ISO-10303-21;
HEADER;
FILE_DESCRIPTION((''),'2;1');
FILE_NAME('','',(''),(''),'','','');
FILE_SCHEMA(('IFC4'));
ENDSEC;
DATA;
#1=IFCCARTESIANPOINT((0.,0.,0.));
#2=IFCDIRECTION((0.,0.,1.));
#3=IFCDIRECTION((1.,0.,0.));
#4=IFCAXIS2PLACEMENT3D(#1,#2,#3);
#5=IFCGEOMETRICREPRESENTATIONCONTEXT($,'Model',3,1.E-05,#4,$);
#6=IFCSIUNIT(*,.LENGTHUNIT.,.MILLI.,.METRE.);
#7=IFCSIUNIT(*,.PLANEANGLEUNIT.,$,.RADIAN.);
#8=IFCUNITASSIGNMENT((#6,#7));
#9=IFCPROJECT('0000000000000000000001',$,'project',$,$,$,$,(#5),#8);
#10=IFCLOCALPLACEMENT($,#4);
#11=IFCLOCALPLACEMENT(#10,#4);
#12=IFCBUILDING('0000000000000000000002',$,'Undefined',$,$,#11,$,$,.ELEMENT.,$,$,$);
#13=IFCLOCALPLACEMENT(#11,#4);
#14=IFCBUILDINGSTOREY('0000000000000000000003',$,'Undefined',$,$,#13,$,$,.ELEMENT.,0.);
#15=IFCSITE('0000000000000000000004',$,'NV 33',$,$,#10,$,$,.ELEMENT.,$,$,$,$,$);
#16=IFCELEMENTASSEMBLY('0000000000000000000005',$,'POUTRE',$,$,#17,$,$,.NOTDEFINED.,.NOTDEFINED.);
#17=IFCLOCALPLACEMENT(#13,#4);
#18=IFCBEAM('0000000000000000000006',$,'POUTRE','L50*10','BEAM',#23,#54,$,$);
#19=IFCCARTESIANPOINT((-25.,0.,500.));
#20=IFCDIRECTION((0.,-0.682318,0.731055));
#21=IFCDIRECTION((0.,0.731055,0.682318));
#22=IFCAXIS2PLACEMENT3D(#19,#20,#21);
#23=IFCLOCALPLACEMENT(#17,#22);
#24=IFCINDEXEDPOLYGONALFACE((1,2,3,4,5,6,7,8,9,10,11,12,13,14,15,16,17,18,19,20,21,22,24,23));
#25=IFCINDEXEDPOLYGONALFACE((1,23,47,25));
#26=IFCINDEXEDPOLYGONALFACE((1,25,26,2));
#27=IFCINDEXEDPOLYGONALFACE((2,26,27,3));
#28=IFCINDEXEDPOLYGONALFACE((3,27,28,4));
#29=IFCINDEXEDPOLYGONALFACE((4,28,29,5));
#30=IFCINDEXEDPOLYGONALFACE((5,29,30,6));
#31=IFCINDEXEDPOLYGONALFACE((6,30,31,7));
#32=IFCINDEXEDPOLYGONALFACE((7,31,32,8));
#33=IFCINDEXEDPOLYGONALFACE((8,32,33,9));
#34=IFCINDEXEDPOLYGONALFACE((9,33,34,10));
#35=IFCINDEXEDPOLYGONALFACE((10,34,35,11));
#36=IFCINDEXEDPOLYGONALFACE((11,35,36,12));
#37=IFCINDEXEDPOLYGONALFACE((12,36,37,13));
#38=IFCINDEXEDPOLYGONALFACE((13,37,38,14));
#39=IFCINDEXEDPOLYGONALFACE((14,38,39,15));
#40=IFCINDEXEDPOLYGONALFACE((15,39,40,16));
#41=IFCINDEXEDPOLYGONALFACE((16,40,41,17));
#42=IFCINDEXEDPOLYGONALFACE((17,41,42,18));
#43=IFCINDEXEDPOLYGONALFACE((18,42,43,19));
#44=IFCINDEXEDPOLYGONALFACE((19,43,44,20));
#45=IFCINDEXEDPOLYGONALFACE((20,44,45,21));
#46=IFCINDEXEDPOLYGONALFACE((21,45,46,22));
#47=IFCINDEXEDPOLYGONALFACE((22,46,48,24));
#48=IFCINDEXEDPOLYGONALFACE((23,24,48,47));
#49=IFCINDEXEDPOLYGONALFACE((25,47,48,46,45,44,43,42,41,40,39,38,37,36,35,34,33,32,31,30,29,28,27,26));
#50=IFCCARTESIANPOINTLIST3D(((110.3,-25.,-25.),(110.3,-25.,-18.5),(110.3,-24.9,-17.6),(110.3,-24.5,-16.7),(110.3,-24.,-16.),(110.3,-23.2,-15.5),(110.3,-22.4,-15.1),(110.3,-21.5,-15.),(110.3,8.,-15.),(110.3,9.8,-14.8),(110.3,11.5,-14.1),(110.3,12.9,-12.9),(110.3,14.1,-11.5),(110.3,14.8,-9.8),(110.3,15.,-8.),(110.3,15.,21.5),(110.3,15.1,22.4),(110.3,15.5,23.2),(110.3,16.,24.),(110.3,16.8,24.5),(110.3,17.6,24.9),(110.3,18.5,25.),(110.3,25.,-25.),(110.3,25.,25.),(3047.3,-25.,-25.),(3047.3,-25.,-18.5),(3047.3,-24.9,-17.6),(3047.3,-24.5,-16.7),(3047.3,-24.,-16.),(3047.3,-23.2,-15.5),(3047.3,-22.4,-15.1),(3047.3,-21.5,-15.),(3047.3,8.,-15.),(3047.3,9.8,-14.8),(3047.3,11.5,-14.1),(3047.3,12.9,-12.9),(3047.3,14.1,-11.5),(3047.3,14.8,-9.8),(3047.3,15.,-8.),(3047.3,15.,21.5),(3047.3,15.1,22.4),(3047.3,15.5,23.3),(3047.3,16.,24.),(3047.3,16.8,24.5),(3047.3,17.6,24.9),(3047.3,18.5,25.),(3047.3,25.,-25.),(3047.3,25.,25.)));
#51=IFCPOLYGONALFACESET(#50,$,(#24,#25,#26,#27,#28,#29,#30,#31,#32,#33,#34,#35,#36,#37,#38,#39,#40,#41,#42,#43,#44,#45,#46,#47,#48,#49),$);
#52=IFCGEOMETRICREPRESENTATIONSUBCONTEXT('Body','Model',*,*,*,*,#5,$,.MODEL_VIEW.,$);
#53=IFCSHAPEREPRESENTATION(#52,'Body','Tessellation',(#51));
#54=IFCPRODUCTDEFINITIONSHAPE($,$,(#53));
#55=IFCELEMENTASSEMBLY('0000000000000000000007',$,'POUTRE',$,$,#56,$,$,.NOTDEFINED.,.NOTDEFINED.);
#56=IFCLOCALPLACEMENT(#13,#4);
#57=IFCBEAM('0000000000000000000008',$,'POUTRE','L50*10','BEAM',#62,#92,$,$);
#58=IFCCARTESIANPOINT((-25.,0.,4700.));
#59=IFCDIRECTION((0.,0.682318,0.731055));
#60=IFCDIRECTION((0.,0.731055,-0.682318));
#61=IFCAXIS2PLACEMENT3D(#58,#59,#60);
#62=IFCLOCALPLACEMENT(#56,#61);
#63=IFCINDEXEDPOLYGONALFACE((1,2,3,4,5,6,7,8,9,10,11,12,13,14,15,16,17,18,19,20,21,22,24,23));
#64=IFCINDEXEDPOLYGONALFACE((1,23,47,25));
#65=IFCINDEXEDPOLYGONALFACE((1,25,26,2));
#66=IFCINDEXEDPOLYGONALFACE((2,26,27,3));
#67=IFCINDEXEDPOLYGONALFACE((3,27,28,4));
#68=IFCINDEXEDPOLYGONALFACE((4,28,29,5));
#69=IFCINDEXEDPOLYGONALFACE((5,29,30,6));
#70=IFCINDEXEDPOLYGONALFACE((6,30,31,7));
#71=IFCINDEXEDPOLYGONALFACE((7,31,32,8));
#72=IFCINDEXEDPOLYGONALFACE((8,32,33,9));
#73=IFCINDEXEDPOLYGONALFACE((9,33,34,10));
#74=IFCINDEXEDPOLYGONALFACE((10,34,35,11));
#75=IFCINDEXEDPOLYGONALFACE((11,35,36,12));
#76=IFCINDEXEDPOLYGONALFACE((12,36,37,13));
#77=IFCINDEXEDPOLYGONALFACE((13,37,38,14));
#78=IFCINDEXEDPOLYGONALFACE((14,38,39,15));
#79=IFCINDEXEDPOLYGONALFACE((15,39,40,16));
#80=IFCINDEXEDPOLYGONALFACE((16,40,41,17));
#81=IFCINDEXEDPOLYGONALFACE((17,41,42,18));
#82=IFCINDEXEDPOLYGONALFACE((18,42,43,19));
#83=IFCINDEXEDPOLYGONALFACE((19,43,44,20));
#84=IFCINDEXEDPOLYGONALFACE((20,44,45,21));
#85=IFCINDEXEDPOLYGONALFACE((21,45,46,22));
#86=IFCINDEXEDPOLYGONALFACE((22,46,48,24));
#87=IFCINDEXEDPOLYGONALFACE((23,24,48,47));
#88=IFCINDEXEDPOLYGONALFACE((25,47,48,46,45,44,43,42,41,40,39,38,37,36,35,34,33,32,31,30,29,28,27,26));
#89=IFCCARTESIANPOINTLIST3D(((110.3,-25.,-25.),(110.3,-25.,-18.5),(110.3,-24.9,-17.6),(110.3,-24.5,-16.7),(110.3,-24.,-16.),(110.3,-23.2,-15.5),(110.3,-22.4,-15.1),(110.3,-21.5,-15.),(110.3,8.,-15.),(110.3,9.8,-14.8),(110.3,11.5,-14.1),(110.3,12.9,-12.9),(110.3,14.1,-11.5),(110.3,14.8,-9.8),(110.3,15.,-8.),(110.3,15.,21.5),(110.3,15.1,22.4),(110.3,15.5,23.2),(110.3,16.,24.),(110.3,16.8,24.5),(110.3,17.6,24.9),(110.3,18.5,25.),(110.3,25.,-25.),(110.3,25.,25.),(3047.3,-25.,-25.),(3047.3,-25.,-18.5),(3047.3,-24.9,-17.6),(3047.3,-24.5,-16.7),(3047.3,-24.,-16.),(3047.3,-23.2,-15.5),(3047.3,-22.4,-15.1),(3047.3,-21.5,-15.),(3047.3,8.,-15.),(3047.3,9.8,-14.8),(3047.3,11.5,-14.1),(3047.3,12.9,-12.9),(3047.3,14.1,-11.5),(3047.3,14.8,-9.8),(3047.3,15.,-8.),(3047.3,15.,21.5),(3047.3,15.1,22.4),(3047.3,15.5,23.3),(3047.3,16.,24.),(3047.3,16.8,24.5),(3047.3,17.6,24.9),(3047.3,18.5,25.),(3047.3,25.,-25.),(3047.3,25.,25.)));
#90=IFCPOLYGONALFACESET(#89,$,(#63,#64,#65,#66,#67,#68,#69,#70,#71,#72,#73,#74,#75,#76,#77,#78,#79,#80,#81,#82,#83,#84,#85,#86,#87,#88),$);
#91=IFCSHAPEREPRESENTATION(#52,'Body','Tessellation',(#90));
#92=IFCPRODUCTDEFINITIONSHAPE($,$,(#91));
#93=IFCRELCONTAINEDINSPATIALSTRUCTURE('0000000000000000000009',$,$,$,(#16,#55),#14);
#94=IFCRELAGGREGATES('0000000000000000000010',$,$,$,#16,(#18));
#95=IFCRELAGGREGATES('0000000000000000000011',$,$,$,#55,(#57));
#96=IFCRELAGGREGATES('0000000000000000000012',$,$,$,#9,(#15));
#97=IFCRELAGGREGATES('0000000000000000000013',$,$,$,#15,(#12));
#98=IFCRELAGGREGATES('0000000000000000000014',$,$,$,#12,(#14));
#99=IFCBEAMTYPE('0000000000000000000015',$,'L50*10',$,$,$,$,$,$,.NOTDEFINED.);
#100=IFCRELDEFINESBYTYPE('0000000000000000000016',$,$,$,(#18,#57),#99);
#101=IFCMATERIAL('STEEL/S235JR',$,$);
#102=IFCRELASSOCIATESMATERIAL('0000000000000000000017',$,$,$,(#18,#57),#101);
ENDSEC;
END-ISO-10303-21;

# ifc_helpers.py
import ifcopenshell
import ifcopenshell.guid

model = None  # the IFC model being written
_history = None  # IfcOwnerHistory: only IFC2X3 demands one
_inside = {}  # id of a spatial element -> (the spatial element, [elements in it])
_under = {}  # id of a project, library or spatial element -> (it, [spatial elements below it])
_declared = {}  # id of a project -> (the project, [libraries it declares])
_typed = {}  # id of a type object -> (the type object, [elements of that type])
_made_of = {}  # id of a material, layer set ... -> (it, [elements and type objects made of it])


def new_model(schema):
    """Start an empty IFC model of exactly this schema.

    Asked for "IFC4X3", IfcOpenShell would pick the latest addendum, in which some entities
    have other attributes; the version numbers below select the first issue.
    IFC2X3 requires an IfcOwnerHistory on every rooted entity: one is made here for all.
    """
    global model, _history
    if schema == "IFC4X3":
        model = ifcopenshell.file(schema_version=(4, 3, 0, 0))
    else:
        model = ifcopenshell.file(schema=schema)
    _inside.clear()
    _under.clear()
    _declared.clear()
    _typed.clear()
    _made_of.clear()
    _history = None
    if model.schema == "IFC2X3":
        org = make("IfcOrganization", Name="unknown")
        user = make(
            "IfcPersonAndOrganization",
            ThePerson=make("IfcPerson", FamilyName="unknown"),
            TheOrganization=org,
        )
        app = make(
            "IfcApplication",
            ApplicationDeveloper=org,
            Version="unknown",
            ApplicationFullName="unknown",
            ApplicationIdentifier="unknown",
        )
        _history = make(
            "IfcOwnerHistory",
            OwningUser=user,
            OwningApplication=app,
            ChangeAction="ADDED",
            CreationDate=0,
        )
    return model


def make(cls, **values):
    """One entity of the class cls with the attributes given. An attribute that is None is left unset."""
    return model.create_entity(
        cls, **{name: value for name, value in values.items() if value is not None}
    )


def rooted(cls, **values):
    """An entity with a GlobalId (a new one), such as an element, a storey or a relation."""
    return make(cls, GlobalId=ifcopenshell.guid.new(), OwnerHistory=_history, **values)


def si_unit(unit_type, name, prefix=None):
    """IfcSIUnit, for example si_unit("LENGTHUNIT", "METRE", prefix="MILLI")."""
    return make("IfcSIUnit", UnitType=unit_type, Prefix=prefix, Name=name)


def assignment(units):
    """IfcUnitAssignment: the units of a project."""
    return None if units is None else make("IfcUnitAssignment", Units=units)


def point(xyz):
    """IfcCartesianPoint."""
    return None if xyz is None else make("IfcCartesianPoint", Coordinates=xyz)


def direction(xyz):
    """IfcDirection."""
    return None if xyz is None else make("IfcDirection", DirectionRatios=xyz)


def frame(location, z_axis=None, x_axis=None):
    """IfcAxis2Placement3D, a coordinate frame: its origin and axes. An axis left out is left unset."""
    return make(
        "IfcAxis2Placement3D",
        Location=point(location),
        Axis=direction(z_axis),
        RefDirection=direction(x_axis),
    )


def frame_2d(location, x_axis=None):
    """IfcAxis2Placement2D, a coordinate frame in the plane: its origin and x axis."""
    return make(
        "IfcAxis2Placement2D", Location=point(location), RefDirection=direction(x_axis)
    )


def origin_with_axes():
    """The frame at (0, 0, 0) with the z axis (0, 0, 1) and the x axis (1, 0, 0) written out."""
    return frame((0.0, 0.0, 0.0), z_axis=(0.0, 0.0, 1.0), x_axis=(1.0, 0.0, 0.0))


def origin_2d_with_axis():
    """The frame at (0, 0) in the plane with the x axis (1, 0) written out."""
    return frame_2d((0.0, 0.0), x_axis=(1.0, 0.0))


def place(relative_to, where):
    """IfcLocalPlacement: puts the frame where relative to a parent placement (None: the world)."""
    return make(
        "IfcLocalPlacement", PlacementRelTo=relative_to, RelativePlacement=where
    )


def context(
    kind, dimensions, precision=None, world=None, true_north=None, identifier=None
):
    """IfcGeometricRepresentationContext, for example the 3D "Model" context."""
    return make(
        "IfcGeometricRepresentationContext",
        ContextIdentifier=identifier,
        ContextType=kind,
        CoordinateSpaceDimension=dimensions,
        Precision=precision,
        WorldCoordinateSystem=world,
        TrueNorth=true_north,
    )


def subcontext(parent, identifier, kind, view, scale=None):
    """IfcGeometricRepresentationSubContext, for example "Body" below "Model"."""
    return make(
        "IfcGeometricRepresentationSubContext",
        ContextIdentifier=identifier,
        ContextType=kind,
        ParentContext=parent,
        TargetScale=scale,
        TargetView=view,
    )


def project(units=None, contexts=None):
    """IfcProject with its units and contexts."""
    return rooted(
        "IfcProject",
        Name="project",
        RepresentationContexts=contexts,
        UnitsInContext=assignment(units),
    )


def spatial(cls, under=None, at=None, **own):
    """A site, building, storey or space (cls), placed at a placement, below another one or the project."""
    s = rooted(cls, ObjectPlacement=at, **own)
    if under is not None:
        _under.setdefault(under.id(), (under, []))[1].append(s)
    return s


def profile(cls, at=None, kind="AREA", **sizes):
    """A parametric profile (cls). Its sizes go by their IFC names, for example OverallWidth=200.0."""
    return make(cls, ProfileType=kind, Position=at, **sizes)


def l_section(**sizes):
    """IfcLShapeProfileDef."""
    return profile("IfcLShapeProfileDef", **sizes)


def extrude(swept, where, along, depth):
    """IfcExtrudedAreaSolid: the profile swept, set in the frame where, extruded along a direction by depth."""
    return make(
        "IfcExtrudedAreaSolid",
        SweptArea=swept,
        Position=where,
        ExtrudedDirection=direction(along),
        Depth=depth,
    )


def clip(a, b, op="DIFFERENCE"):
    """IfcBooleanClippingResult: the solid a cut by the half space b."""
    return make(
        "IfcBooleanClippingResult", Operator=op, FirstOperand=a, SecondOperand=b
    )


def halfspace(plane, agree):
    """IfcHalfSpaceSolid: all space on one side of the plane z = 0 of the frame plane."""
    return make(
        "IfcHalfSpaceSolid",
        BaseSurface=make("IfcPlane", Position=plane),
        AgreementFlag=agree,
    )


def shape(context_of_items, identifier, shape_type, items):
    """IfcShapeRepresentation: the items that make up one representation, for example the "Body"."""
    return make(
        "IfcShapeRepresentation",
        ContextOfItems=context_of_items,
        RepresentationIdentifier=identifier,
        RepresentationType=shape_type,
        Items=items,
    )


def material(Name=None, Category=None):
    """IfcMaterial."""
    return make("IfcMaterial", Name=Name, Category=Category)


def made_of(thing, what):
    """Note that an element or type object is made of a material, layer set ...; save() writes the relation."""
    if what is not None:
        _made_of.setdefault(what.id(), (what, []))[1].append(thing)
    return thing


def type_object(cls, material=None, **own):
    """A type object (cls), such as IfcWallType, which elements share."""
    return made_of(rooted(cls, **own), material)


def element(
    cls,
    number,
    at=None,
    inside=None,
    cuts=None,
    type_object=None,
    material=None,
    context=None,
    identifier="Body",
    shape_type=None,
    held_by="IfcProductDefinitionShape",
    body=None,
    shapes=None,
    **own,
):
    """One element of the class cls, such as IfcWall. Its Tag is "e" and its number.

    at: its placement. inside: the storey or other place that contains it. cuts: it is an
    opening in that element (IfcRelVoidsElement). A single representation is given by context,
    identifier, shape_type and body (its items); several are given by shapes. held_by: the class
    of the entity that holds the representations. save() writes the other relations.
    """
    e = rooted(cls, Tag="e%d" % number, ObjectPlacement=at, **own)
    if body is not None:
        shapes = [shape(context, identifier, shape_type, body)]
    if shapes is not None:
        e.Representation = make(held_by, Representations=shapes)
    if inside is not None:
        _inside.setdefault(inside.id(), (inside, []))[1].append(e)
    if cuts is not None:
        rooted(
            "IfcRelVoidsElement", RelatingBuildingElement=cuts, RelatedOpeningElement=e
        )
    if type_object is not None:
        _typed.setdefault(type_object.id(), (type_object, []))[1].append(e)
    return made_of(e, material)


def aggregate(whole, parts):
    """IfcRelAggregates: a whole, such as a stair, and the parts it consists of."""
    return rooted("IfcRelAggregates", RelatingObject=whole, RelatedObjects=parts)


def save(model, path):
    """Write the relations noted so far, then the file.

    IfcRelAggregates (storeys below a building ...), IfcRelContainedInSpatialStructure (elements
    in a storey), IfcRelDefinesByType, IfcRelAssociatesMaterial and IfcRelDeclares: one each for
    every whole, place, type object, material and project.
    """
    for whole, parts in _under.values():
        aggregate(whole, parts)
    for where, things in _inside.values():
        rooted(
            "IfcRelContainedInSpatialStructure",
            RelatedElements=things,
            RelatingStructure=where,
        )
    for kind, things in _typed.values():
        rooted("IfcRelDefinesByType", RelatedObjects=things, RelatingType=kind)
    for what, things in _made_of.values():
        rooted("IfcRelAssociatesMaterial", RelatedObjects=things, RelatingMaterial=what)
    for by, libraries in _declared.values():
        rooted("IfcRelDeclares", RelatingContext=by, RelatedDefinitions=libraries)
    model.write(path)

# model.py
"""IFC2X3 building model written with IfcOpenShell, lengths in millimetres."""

from ifc_helpers import new_model, si_unit, frame, origin_with_axes, origin_2d_with_axis, place, context, subcontext, project, spatial, l_section, extrude, clip, halfspace, material, type_object, element, aggregate, save


model = new_model("IFC2X3")

# Units and contexts
model_context = context("Model", 3, precision=1e-05, world=origin_with_axes())
body_context = subcontext(model_context, "Body", "Model", "MODEL_VIEW")
ifc_project = project(units=[si_unit("LENGTHUNIT", "METRE", prefix="MILLI"), si_unit("PLANEANGLEUNIT", "RADIAN")], contexts=[model_context])

# Site, building, storey
site_placement = place(None, origin_with_axes())
site = spatial("IfcSite", under=ifc_project, at=site_placement, Name="NV 33", CompositionType="ELEMENT")
building_placement = place(site_placement, origin_with_axes())
building = spatial("IfcBuilding", under=site, at=building_placement, Name="Undefined", CompositionType="ELEMENT")
storey_placement = place(building_placement, origin_with_axes())
storey = spatial("IfcBuildingStorey", under=building, at=storey_placement, Name="Undefined", CompositionType="ELEMENT", Elevation=0.0)

# Shared definitions
ifc_material = material(Name="STEEL/S235JR")

# Element assemblies, beams
assembly_1_placement = place(storey_placement, origin_with_axes())
assembly_1 = element("IfcElementAssembly", 1, at=assembly_1_placement, inside=storey, Name="POUTRE", AssemblyPlace="NOTDEFINED", PredefinedType="NOTDEFINED")
beam_type_1 = type_object("IfcBeamType", Name="L50*10", PredefinedType="NOTDEFINED")
beam_1_placement = place(assembly_1_placement, frame((-25.0, 0.0, 500.0), z_axis=(0.0, -0.682318, 0.731055), x_axis=(0.0, 0.731055, 0.682318)))
beam_1 = element("IfcBeam", 2, at=beam_1_placement, type_object=beam_type_1, material=ifc_material, Name="POUTRE", Description="L50*10", ObjectType="BEAM", context=body_context, shape_type="Clipping", body=[
    clip(clip(extrude(l_section(Depth=50.0, Width=50.0, Thickness=10.0, FilletRadius=7.0, EdgeRadius=3.5, at=origin_2d_with_axis()), frame((3097.7, 0.0, 0.0), z_axis=(-1.0, 0.0, 0.0), x_axis=(0.0, -1.0, 0.0)), (0.0, 0.0, 1.0), 3097.7), halfspace(frame((3047.3, 0.0, -25.0), z_axis=(-1.0, 0.0, 0.0), x_axis=(0.0, 1.0, 0.0)), True)), halfspace(frame((110.3, 31.0, 0.0), z_axis=(1.0, 0.0, 0.0), x_axis=(0.0, 0.0, -1.0)), True)),
])
aggregate(assembly_1, [beam_1])
assembly_2_placement = place(storey_placement, origin_with_axes())
assembly_2 = element("IfcElementAssembly", 3, at=assembly_2_placement, inside=storey, Name="POUTRE", AssemblyPlace="NOTDEFINED", PredefinedType="NOTDEFINED")
beam_2_placement = place(assembly_2_placement, frame((-25.0, 0.0, 4700.0), z_axis=(0.0, 0.682318, 0.731055), x_axis=(0.0, 0.731055, -0.682318)))
beam_2 = element("IfcBeam", 4, at=beam_2_placement, type_object=beam_type_1, material=ifc_material, Name="POUTRE", Description="L50*10", ObjectType="BEAM", context=body_context, shape_type="Clipping", body=[
    clip(clip(extrude(l_section(Depth=50.0, Width=50.0, Thickness=10.0, FilletRadius=7.0, EdgeRadius=3.5, at=origin_2d_with_axis()), frame((3097.7, 0.0, 0.0), z_axis=(-1.0, 0.0, 0.0), x_axis=(0.0, -1.0, 0.0)), (0.0, 0.0, 1.0), 3097.7), halfspace(frame((3047.3, 0.0, -25.0), z_axis=(-1.0, 0.0, 0.0), x_axis=(0.0, 1.0, 0.0)), True)), halfspace(frame((110.3, 31.0, 0.0), z_axis=(1.0, 0.0, 0.0), x_axis=(0.0, 0.0, -1.0)), True)),
])
aggregate(assembly_2, [beam_2])

save(model, "model.ifc")
